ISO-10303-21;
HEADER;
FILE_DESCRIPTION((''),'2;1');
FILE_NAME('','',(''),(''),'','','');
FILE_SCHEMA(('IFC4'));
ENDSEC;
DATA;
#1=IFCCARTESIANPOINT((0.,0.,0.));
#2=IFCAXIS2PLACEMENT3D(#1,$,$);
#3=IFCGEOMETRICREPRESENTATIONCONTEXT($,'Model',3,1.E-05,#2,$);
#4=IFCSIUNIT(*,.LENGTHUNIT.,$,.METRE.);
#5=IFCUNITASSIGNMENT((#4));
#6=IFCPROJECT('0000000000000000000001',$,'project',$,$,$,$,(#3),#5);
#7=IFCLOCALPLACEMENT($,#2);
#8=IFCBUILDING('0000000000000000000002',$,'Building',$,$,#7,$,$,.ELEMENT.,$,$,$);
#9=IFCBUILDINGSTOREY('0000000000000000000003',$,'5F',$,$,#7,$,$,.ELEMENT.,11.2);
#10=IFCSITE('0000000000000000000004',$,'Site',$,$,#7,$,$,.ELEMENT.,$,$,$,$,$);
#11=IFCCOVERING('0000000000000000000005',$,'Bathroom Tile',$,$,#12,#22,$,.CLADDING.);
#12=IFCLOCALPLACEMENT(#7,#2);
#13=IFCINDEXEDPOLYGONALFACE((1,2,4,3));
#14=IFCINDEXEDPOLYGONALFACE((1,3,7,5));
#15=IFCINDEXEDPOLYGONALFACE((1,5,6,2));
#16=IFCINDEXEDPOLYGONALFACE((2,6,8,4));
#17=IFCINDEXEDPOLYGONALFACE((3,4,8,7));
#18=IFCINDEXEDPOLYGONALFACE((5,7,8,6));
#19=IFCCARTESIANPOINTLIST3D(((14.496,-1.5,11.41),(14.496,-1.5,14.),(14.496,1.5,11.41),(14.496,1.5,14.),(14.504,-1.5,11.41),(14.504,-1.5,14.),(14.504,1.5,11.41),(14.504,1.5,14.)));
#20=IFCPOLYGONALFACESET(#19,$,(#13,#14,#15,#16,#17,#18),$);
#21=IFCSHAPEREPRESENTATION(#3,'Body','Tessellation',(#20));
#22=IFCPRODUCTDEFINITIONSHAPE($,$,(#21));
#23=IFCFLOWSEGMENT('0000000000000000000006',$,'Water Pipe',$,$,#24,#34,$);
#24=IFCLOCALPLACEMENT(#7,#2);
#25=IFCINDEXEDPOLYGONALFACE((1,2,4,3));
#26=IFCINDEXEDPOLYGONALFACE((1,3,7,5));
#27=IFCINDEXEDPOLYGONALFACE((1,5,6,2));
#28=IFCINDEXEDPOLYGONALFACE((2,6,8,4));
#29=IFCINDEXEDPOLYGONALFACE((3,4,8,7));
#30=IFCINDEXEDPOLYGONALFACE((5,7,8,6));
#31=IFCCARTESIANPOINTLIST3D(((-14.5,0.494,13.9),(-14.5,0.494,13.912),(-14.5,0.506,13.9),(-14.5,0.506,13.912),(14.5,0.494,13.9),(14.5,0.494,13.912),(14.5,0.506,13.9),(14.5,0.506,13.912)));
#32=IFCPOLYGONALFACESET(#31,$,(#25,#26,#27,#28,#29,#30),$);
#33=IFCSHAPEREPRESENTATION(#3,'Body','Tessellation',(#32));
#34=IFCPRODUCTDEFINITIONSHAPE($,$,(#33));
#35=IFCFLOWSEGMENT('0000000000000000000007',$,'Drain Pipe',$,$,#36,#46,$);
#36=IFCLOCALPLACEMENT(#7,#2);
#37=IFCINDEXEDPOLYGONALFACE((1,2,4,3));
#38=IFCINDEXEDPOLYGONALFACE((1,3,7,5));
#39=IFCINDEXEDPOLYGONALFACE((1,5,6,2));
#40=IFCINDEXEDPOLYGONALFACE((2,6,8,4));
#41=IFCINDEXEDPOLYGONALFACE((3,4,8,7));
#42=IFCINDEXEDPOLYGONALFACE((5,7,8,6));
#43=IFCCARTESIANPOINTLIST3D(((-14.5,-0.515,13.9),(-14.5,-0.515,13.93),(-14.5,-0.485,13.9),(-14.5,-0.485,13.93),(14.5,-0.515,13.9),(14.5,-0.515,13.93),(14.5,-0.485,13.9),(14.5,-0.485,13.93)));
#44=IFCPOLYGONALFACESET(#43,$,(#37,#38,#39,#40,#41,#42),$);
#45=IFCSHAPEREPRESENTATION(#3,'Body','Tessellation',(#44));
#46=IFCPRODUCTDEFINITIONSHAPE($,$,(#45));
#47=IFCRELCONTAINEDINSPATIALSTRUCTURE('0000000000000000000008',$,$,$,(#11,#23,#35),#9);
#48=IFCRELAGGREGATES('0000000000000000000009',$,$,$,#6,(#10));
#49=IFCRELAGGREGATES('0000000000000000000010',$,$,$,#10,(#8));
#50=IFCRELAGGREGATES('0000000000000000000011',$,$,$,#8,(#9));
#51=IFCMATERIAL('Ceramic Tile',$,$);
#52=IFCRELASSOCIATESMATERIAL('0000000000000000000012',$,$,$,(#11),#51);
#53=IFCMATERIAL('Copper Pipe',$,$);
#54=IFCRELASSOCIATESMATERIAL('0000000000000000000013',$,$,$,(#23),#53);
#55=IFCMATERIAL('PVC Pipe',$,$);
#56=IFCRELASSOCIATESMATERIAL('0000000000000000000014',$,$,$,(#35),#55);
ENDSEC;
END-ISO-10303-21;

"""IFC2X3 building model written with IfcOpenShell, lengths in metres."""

from ifc_helpers import new_model, si_unit, frame, origin, origin_2d, place, context, project, spatial, rectangle, extrude, material, element, save


model = new_model("IFC2X3")

# Units and contexts
model_context = context("Model", 3, precision=1e-05, world=origin())
ifc_project = project(units=[si_unit("LENGTHUNIT", "METRE")], contexts=[model_context])

# Site, building, storey
placement = place(None, origin())
site = spatial("IfcSite", under=ifc_project, at=placement, Name="Site", CompositionType="ELEMENT")
building = spatial("IfcBuilding", under=site, at=placement, Name="Building", CompositionType="ELEMENT")
storey = spatial("IfcBuildingStorey", under=building, at=placement, Name="5F", CompositionType="ELEMENT", Elevation=11.2)

# Covering
ifc_material_1 = material(Name="Ceramic Tile")
covering_1_placement = place(None, frame((14.5, 0.0, 11.41)))
element("IfcCovering", 1, at=covering_1_placement, inside=storey, material=ifc_material_1, Name="Bathroom Tile", PredefinedType="CLADDING", context=model_context, shape_type="SweptSolid", body=[
    extrude(rectangle(XDim=0.008, YDim=3.0, at=origin_2d()), origin(), (0.0, 0.0, 1.0), 2.59),
])

# Flow segments
ifc_material_2 = material(Name="Copper Pipe")
flow_segment_1_placement = place(None, frame((0.0, 0.5, 13.9)))
element("IfcFlowSegment", 2, at=flow_segment_1_placement, inside=storey, material=ifc_material_2, Name="Water Pipe", context=model_context, shape_type="SweptSolid", body=[
    extrude(rectangle(XDim=29.0, YDim=0.012, at=origin_2d()), origin(), (0.0, 0.0, 1.0), 0.012),
])
ifc_material_3 = material(Name="PVC Pipe")
flow_segment_2_placement = place(None, frame((0.0, -0.5, 13.9)))
element("IfcFlowSegment", 3, at=flow_segment_2_placement, inside=storey, material=ifc_material_3, Name="Drain Pipe", context=model_context, shape_type="SweptSolid", body=[
    extrude(rectangle(XDim=29.0, YDim=0.03, at=origin_2d()), origin(), (0.0, 0.0, 1.0), 0.03),
])

save(model, "model.ifc")
